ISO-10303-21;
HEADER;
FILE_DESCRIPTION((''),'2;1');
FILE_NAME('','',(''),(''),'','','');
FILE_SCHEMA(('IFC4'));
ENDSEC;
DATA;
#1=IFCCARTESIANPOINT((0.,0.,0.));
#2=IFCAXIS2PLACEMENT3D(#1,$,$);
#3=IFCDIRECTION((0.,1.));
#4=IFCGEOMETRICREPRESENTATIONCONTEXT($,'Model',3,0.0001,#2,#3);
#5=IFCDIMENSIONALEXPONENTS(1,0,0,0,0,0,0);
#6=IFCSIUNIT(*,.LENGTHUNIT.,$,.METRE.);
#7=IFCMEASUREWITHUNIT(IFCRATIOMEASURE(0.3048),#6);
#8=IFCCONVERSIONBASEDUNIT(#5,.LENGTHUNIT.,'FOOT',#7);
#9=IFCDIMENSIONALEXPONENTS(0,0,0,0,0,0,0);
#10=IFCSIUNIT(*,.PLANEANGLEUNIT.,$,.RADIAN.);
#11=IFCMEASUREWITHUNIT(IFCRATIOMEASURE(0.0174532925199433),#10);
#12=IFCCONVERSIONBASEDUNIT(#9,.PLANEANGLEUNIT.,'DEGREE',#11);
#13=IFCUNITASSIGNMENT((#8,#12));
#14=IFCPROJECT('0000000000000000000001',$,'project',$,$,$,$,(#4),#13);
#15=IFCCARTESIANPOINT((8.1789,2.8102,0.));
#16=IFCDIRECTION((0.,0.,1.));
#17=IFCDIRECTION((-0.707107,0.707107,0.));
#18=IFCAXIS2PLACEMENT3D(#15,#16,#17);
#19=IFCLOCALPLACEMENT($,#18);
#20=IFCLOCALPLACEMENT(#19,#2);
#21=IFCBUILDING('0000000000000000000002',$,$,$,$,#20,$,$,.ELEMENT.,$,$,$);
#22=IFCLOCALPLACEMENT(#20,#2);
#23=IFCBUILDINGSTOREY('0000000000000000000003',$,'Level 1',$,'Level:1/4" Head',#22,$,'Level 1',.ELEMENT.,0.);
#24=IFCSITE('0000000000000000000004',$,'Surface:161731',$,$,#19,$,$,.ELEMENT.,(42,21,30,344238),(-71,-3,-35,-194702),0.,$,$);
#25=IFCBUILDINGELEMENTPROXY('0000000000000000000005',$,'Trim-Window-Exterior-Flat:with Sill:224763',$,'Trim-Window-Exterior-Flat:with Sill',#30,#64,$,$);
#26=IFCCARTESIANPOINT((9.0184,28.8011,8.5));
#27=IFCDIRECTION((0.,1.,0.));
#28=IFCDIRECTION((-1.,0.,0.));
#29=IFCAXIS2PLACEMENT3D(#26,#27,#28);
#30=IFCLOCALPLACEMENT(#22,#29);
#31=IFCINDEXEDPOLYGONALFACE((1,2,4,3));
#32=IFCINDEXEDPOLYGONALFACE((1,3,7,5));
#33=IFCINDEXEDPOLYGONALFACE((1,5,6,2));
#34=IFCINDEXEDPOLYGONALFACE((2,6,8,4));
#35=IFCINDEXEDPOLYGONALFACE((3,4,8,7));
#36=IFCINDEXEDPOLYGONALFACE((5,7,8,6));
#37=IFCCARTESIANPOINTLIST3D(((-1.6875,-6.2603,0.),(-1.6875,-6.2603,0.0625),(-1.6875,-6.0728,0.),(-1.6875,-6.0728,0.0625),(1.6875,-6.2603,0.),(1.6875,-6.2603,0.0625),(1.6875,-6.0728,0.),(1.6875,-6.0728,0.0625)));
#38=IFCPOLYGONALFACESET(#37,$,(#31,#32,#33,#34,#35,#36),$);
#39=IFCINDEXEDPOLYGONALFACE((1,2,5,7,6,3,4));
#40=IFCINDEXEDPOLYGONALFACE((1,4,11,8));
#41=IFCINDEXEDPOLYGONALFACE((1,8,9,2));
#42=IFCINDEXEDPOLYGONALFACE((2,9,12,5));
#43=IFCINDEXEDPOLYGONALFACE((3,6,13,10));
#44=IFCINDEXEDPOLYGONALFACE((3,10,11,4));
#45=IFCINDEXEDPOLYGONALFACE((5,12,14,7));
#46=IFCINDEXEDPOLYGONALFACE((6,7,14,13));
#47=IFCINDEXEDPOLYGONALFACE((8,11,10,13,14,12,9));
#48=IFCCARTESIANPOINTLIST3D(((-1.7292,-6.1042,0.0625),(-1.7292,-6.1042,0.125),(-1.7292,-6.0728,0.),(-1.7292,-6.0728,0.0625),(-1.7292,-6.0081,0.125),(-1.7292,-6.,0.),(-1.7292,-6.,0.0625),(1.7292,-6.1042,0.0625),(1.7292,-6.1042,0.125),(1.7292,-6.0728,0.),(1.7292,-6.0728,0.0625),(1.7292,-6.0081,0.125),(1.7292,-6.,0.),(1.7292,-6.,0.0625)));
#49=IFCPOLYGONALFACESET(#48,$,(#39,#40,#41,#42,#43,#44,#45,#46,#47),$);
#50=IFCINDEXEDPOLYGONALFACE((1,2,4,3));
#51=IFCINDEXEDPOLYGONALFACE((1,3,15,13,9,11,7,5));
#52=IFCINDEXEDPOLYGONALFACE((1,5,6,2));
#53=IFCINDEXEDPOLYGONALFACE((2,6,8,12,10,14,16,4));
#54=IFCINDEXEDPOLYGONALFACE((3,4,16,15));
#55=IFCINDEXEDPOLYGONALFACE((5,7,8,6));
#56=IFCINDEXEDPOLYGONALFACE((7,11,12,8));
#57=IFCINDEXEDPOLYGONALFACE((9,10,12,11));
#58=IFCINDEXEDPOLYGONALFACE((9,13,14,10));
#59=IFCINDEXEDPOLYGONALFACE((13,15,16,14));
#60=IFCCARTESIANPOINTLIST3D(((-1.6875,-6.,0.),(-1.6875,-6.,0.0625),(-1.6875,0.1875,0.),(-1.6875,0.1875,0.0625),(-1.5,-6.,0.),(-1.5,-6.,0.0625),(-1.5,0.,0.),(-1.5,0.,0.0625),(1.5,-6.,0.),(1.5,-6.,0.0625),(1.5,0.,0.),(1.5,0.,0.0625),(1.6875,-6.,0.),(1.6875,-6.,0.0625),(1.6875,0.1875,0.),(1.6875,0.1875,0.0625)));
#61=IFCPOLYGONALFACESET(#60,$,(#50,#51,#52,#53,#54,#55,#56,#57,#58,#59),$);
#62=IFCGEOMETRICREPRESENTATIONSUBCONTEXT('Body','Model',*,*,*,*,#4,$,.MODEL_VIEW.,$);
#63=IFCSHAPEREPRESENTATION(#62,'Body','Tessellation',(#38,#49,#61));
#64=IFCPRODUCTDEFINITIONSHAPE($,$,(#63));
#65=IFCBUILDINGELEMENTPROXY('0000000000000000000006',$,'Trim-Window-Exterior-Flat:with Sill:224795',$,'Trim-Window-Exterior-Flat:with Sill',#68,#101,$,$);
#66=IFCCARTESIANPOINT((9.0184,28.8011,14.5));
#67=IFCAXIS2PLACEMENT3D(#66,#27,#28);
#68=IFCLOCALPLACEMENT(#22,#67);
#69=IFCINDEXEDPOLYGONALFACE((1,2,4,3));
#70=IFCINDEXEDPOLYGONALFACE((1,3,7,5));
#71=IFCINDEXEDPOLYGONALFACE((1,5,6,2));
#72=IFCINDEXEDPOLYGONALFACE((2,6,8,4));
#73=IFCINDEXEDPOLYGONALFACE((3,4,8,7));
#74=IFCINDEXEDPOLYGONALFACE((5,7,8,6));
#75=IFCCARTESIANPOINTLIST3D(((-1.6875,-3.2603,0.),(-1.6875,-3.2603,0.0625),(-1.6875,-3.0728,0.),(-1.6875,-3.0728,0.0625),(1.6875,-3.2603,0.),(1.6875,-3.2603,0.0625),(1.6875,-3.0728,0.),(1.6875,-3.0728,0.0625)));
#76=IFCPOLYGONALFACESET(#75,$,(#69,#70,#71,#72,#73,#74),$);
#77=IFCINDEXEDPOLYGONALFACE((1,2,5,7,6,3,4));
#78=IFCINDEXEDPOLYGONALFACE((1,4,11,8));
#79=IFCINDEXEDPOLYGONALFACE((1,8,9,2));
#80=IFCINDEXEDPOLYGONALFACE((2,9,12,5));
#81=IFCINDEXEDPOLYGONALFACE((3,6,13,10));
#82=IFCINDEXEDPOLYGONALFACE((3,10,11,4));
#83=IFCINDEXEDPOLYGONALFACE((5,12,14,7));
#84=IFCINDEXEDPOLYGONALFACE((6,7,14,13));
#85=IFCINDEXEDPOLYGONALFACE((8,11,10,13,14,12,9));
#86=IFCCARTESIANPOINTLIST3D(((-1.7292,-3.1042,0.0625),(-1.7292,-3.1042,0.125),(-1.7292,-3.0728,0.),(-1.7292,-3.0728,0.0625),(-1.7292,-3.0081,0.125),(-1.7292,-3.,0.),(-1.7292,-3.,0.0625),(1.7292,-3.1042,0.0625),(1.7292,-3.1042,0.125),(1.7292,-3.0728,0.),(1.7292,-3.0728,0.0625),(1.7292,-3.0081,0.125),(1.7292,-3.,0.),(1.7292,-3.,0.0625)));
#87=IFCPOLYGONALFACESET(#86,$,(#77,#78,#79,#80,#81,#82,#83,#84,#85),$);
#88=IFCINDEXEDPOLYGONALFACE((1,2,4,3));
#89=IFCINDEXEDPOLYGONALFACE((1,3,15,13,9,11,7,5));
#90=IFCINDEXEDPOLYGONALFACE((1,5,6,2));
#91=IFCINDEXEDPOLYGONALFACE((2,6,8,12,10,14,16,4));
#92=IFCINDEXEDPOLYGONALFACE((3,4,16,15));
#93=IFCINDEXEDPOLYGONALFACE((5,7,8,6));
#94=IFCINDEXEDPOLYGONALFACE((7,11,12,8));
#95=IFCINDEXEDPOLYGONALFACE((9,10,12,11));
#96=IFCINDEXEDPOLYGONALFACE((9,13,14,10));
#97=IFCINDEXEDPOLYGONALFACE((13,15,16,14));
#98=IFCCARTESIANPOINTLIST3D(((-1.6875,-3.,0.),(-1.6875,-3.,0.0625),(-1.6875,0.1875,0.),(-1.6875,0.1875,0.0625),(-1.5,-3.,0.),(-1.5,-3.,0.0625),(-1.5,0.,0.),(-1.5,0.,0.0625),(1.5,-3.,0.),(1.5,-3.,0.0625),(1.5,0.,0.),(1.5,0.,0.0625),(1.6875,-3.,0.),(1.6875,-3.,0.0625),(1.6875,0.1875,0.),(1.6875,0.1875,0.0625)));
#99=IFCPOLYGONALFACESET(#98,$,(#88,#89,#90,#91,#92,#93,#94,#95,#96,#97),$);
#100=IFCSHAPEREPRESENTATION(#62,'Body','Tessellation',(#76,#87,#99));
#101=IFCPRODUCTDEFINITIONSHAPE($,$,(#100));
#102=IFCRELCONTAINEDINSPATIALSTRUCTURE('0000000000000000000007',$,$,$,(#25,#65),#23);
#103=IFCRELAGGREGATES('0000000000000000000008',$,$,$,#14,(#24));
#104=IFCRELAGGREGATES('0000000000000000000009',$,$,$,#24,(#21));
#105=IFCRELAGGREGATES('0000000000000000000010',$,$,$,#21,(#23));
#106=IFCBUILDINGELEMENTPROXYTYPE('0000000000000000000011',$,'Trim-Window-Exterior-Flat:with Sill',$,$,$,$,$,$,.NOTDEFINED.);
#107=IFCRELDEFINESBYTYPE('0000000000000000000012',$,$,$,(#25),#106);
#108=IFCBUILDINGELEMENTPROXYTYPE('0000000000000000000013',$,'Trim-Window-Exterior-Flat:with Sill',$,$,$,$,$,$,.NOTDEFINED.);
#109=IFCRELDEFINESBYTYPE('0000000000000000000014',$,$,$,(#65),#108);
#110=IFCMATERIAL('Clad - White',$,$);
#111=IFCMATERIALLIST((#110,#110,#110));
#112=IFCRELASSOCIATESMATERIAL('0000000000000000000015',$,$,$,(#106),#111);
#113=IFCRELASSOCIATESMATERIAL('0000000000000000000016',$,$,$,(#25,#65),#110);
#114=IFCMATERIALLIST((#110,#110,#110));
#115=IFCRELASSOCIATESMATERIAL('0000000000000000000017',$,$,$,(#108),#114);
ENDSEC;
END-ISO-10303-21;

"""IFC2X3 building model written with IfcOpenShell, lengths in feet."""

from ifc_helpers import new_model, entity, si_unit, converted_unit, direction, frame, frame_2d, origin, origin_2d_with_axis, place, context, subcontext, project, spatial, polyline, rectangle, outline, extrude, source, transform, mapped, material, material_list, type_object, type_shapes, element, save


model = new_model("IFC2X3")

# Units and contexts
model_context = context("Model", 3, precision=0.0001, world=origin(), true_north=direction((0.0, 1.0)))
body_context = subcontext(model_context, "Body", "Model", "MODEL_VIEW")
ifc_project = project(units=[converted_unit("LENGTHUNIT", "FOOT", entity("IfcRatioMeasure", 0.3048), si_unit("LENGTHUNIT", "METRE"), dimensions=[1, 0, 0, 0, 0, 0, 0]), converted_unit("PLANEANGLEUNIT", "DEGREE", entity("IfcRatioMeasure", 0.0174532925199433), si_unit("PLANEANGLEUNIT", "RADIAN"), dimensions=[0, 0, 0, 0, 0, 0, 0])], contexts=[model_context])

# Site, building, storey
site_placement = place(None, frame((8.1789, 2.8102, 0.0), z_axis=(0.0, 0.0, 1.0), x_axis=(-0.707107, 0.707107, 0.0)))
site = spatial("IfcSite", under=ifc_project, at=site_placement, Name="Surface:161731", CompositionType="ELEMENT", RefLatitude=(42, 21, 30, 344238), RefLongitude=(-71, -3, -35, -194702), RefElevation=0.0)
building_placement = place(site_placement, origin())
building = spatial("IfcBuilding", under=site, at=building_placement, CompositionType="ELEMENT")
storey_placement = place(building_placement, origin())
storey = spatial("IfcBuildingStorey", under=building, at=storey_placement, Name="Level 1", ObjectType="Level:1/4\" Head", LongName="Level 1", CompositionType="ELEMENT", Elevation=0.0)

# Building element proxies
ifc_material_1 = material(Name="Clad - White")
ifc_material_list_1 = material_list([ifc_material_1, ifc_material_1, ifc_material_1])
building_element_proxy_type_1 = type_object("IfcBuildingElementProxyType", Name="Trim-Window-Exterior-Flat:with Sill", PredefinedType="NOTDEFINED", material=ifc_material_list_1)
shared_shape_1 = source(origin(), body_context, "Body", "SweptSolid", [
    extrude(rectangle(XDim=3.375, YDim=0.1875, at=origin_2d_with_axis()), frame((0.0, -6.1665, 0.0), z_axis=(0.0, 0.0, 1.0), x_axis=(-1.0, 0.0, 0.0)), (0.0, 0.0, 1.0), 0.0625),
    extrude(outline(polyline([(-0.0625, -0.0525), (0.0, -0.0525), (0.0, -0.0211), (0.0625, -0.0211), (0.0625, 0.0517), (0.0, 0.0517), (-0.0625, 0.0436), (-0.0625, -0.0525)])), frame((-1.7292, -6.0517, 0.0625), z_axis=(1.0, 0.0, 0.0), x_axis=(0.0, 0.0, -1.0)), (0.0, 0.0, 1.0), 3.4583),
    extrude(outline(polyline([(-3.1406, -1.6875), (3.0469, -1.6875), (3.0469, -1.5), (-2.9531, -1.5), (-2.9531, 1.5), (3.0469, 1.5), (3.0469, 1.6875), (-3.1406, 1.6875), (-3.1406, -1.6875)])), frame((0.0, -2.9531, 0.0), z_axis=(0.0, 0.0, 1.0), x_axis=(0.0, -1.0, 0.0)), (0.0, 0.0, 1.0), 0.0625),
])
type_shapes(building_element_proxy_type_1, [shared_shape_1])
proxy_1_placement = place(storey_placement, frame((9.0184, 28.8011, 8.5), z_axis=(0.0, 1.0, 0.0), x_axis=(-1.0, 0.0, 0.0)))
element("IfcBuildingElementProxy", 1, at=proxy_1_placement, inside=storey, type_object=building_element_proxy_type_1, material=ifc_material_1, Name="Trim-Window-Exterior-Flat:with Sill:224763", ObjectType="Trim-Window-Exterior-Flat:with Sill", context=body_context, shape_type="MappedRepresentation", body=[
    mapped(shared_shape_1, transform((0.0, 0.0, 0.0), scale=1.0)),
])
ifc_material_list_2 = material_list([ifc_material_1, ifc_material_1, ifc_material_1])
building_element_proxy_type_2 = type_object("IfcBuildingElementProxyType", Name="Trim-Window-Exterior-Flat:with Sill", PredefinedType="NOTDEFINED", material=ifc_material_list_2)
shared_shape_2 = source(origin(), body_context, "Body", "SweptSolid", [
    extrude(rectangle(XDim=3.375, YDim=0.1875, at=frame_2d((0.0, 0.0), x_axis=(1.0, 0.0))), frame((0.0, -3.1665, 0.0), z_axis=(0.0, 0.0, 1.0), x_axis=(-1.0, 0.0, 0.0)), (0.0, 0.0, 1.0), 0.0625),
    extrude(outline(polyline([(-0.0625, -0.0525), (0.0, -0.0525), (0.0, -0.0211), (0.0625, -0.0211), (0.0625, 0.0517), (0.0, 0.0517), (-0.0625, 0.0436), (-0.0625, -0.0525)])), frame((-1.7292, -3.0517, 0.0625), z_axis=(1.0, 0.0, 0.0), x_axis=(0.0, 0.0, -1.0)), (0.0, 0.0, 1.0), 3.4583),
    extrude(outline(polyline([(-1.6406, -1.6875), (1.5469, -1.6875), (1.5469, -1.5), (-1.4531, -1.5), (-1.4531, 1.5), (1.5469, 1.5), (1.5469, 1.6875), (-1.6406, 1.6875), (-1.6406, -1.6875)])), frame((0.0, -1.4531, 0.0), z_axis=(0.0, 0.0, 1.0), x_axis=(0.0, -1.0, 0.0)), (0.0, 0.0, 1.0), 0.0625),
])
type_shapes(building_element_proxy_type_2, [shared_shape_2])
proxy_2_placement = place(storey_placement, frame((9.0184, 28.8011, 14.5), z_axis=(0.0, 1.0, 0.0), x_axis=(-1.0, 0.0, 0.0)))
element("IfcBuildingElementProxy", 2, at=proxy_2_placement, inside=storey, type_object=building_element_proxy_type_2, material=ifc_material_1, Name="Trim-Window-Exterior-Flat:with Sill:224795", ObjectType="Trim-Window-Exterior-Flat:with Sill", context=body_context, shape_type="MappedRepresentation", body=[
    mapped(shared_shape_2, transform((0.0, 0.0, 0.0), scale=1.0)),
])

save(model, "model.ifc")
